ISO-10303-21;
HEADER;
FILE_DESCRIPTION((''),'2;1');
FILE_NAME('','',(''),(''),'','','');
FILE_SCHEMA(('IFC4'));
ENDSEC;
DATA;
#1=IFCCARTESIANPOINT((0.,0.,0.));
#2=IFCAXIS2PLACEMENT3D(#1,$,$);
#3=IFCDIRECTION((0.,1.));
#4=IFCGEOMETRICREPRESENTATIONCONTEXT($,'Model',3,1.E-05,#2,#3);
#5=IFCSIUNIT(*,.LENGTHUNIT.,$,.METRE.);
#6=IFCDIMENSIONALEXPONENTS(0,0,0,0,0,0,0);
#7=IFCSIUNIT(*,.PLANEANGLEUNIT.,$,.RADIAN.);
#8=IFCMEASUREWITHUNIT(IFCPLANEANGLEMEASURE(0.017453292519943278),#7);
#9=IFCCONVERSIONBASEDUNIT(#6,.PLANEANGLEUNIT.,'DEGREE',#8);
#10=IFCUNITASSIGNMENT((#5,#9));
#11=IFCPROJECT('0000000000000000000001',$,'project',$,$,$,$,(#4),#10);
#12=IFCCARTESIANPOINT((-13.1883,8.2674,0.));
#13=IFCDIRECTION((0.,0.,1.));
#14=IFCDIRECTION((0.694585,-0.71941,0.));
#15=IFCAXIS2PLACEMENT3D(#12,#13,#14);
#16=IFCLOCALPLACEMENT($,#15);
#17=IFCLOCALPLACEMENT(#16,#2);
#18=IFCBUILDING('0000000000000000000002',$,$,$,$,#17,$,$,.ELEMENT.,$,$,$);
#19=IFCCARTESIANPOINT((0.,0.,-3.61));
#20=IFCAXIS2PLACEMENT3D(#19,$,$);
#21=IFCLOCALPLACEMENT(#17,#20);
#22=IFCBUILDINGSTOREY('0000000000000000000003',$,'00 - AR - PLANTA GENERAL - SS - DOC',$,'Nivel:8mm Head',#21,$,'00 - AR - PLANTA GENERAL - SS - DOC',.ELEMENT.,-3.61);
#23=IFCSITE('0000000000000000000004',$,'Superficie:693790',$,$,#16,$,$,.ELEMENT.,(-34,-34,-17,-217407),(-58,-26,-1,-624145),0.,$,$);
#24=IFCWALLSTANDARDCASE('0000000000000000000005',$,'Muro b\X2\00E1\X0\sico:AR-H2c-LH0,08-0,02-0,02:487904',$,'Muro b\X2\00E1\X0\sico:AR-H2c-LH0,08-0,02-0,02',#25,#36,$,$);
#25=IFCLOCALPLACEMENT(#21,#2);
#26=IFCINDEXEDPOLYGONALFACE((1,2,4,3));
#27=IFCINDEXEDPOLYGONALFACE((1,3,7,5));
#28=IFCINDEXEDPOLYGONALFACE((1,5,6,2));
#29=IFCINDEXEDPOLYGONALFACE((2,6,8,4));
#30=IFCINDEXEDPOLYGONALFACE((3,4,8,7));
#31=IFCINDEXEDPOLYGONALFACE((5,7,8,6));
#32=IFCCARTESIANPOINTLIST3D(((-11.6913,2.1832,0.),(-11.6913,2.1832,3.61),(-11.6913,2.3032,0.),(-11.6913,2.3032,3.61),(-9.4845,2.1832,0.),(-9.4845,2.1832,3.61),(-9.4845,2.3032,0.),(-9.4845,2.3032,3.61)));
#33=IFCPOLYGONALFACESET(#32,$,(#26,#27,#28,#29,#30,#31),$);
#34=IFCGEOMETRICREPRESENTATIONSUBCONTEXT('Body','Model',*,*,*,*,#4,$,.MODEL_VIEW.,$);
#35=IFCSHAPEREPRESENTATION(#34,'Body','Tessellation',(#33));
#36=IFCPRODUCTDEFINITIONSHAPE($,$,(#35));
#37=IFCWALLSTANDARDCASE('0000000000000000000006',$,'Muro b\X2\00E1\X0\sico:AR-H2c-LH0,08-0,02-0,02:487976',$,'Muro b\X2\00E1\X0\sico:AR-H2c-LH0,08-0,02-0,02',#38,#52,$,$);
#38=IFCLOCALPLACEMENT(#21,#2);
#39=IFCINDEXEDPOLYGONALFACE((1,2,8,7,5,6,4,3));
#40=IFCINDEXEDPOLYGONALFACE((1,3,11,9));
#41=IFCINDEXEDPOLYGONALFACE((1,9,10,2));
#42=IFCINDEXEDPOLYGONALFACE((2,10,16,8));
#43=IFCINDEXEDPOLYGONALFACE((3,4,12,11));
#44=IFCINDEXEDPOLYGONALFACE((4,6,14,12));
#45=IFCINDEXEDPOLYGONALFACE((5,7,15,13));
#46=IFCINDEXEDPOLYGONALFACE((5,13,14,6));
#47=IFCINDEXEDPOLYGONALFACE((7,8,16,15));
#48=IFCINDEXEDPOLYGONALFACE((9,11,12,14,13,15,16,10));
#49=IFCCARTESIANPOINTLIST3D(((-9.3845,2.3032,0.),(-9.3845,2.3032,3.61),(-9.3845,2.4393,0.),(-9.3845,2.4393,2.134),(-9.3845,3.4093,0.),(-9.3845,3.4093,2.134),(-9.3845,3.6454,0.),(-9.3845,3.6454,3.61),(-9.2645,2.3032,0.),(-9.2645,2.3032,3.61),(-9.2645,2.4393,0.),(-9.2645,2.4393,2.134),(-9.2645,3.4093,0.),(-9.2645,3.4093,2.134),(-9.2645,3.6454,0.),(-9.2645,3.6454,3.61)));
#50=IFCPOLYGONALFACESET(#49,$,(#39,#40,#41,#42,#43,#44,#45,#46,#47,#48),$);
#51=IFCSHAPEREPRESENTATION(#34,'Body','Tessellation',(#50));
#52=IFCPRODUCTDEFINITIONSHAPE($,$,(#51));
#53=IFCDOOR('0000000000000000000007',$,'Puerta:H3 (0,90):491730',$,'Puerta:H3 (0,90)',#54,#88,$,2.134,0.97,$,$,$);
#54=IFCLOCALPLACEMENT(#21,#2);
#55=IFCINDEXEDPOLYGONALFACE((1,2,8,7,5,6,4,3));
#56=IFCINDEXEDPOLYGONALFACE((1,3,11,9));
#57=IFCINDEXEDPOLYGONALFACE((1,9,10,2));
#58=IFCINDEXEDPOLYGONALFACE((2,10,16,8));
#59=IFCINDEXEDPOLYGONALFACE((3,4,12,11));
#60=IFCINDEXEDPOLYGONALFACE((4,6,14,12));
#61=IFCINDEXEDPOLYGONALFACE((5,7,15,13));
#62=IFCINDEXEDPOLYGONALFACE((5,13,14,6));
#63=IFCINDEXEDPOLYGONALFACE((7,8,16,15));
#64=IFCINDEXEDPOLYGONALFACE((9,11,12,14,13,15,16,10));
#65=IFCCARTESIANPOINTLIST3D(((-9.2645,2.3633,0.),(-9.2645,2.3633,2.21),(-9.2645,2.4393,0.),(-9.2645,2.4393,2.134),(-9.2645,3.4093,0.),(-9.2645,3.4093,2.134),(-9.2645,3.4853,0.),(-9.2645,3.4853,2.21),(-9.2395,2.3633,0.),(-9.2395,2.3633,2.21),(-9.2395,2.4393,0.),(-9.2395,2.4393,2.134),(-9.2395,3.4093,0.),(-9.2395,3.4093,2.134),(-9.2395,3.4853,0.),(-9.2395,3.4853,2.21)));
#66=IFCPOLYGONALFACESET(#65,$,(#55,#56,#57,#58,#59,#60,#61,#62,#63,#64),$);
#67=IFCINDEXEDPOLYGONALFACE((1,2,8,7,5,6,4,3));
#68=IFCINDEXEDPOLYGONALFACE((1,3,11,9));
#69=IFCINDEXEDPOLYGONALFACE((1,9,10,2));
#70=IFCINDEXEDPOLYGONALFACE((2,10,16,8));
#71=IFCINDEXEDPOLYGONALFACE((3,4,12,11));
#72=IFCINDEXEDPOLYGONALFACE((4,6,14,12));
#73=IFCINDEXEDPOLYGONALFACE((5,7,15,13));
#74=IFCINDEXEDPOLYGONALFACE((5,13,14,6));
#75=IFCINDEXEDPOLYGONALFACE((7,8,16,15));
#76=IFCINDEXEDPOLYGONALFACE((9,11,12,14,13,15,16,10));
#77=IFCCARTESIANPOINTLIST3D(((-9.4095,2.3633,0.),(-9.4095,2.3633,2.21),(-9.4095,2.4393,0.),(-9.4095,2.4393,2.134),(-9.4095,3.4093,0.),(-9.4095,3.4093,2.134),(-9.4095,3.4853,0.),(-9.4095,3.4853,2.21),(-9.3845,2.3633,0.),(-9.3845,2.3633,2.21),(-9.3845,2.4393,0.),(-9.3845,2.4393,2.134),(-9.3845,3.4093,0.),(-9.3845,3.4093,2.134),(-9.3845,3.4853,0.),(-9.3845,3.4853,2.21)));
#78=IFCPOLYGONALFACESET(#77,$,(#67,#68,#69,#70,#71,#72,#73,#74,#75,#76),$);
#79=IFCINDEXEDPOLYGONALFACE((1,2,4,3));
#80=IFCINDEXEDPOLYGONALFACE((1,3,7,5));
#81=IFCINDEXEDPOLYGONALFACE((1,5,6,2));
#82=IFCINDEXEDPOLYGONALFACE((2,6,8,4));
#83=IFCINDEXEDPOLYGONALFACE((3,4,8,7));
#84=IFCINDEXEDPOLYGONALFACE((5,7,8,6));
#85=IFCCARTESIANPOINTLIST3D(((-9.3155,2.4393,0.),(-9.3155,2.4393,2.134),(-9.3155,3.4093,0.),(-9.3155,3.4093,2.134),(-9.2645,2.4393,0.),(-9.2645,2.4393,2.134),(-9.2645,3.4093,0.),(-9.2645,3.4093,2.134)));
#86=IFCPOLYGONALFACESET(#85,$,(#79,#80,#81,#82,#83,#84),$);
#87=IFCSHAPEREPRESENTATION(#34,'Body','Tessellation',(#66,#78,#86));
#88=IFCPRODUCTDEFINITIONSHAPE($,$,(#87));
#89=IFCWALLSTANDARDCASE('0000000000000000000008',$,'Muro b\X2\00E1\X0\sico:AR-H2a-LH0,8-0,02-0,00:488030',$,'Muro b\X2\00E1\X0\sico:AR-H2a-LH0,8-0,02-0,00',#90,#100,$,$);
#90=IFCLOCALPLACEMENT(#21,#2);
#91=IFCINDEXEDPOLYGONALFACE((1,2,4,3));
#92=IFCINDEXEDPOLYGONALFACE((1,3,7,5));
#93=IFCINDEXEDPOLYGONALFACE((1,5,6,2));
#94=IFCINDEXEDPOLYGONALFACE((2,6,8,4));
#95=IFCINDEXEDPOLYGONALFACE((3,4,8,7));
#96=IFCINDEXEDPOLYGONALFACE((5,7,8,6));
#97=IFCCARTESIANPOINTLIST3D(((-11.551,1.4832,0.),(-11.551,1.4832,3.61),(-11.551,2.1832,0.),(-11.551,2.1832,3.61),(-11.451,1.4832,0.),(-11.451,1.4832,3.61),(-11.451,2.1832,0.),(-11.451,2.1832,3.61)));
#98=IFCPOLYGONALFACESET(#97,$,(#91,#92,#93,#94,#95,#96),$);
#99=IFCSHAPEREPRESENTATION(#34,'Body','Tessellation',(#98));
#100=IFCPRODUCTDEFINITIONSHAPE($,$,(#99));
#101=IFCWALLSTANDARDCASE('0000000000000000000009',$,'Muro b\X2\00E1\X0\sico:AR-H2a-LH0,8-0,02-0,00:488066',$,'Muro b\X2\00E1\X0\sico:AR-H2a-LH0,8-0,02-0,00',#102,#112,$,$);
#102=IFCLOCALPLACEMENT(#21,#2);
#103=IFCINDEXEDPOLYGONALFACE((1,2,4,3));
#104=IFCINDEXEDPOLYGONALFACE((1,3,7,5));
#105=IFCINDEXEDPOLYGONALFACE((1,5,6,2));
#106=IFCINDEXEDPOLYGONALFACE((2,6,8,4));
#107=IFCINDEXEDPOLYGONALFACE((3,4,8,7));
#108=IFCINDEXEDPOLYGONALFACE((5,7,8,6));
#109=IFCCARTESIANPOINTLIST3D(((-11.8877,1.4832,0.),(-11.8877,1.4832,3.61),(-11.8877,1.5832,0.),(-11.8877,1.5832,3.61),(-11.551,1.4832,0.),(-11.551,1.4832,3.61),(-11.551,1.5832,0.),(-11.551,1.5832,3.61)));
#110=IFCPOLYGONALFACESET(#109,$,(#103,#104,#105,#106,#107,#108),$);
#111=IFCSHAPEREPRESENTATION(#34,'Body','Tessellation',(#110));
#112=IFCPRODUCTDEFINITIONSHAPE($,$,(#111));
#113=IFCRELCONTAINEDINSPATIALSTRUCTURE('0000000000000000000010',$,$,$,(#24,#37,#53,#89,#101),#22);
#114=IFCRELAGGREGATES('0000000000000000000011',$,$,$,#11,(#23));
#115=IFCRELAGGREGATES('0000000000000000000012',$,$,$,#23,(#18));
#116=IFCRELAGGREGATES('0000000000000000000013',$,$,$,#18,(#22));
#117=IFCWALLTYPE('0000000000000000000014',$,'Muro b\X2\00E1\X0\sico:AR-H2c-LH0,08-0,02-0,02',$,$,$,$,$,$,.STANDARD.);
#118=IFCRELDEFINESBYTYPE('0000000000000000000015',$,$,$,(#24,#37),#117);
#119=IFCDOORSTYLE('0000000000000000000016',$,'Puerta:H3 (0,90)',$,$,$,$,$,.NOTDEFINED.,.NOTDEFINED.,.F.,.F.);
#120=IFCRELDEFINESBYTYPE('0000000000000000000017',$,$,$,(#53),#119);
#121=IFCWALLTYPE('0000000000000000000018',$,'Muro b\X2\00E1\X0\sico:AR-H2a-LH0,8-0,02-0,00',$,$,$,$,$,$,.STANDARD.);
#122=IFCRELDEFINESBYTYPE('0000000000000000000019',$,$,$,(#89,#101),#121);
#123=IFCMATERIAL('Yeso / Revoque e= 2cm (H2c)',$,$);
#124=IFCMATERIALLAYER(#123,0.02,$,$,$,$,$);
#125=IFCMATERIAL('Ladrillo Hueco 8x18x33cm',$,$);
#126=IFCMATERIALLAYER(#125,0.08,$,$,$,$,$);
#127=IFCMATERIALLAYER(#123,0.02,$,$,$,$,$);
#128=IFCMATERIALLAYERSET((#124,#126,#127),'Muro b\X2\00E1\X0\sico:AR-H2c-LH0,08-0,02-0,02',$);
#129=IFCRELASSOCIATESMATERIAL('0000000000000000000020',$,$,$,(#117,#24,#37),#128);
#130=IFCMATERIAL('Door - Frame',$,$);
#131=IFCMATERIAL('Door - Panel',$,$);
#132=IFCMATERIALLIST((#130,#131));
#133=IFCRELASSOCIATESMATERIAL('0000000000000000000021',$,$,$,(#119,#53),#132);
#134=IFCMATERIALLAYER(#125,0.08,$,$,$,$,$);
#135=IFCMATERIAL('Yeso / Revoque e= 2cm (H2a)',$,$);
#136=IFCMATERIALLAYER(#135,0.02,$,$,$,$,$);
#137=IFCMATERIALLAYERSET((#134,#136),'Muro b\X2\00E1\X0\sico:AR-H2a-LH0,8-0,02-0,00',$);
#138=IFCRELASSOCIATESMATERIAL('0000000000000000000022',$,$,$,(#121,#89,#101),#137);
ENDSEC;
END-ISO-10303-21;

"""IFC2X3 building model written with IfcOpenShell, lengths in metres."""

from ifc_helpers import new_model, entity, si_unit, converted_unit, direction, frame, frame_2d, origin, origin_2d_with_axis, place, context, subcontext, project, spatial, polyline, rectangle, outline, extrude, source, transform, mapped, material, material_list, layer, layer_set, layer_usage, type_object, type_shapes, element, fill, save


model = new_model("IFC2X3")

# Units and contexts
model_context = context("Model", 3, precision=1e-05, world=origin(), true_north=direction((0.0, 1.0)))
body_context = subcontext(model_context, "Body", "Model", "MODEL_VIEW")
ifc_project = project(units=[si_unit("LENGTHUNIT", "METRE"), converted_unit("PLANEANGLEUNIT", "DEGREE", entity("IfcPlaneAngleMeasure", 0.017453292519943278), si_unit("PLANEANGLEUNIT", "RADIAN"), dimensions=[0, 0, 0, 0, 0, 0, 0])], contexts=[model_context])

# Site, building, storey
site_placement = place(None, frame((-13.1883, 8.2674, 0.0), z_axis=(0.0, 0.0, 1.0), x_axis=(0.694585, -0.71941, 0.0)))
site = spatial("IfcSite", under=ifc_project, at=site_placement, Name="Superficie:693790", CompositionType="ELEMENT", RefLatitude=(-34, -34, -17, -217407), RefLongitude=(-58, -26, -1, -624145), RefElevation=0.0)
building_placement = place(site_placement, origin())
building = spatial("IfcBuilding", under=site, at=building_placement, CompositionType="ELEMENT")
storey_placement = place(building_placement, frame((0.0, 0.0, -3.61)))
storey = spatial("IfcBuildingStorey", under=building, at=storey_placement, Name="00 - AR - PLANTA GENERAL - SS - DOC", ObjectType="Nivel:8mm Head", LongName="00 - AR - PLANTA GENERAL - SS - DOC", CompositionType="ELEMENT", Elevation=-3.61)

# Wall
ifc_material_1 = material(Name="Yeso / Revoque e= 2cm (H2c)")
ifc_layer_1 = layer(ifc_material_1, 0.02)
ifc_material_2 = material(Name="Ladrillo Hueco 8x18x33cm")
ifc_layer_2 = layer(ifc_material_2, 0.08)
ifc_layer_3 = layer(ifc_material_1, 0.02)
ifc_layer_set_1 = layer_set([ifc_layer_1, ifc_layer_2, ifc_layer_3], Name="Muro básico:AR-H2c-LH0,08-0,02-0,02")
ifc_layer_usage_1 = layer_usage(ifc_layer_set_1, "AXIS2", "NEGATIVE", 0.06)
wall_type_1 = type_object("IfcWallType", Name="Muro básico:AR-H2c-LH0,08-0,02-0,02", PredefinedType="STANDARD", material=ifc_layer_set_1)
wall_1_placement = place(storey_placement, frame((-11.6913, 2.2432, 0.0)))
element("IfcWallStandardCase", 1, at=wall_1_placement, inside=storey, type_object=wall_type_1, material=ifc_layer_usage_1, Name="Muro básico:AR-H2c-LH0,08-0,02-0,02:487904", ObjectType="Muro básico:AR-H2c-LH0,08-0,02-0,02", context=body_context, shape_type="SweptSolid", body=[
    extrude(rectangle(XDim=2.2069, YDim=0.12, at=frame_2d((1.1034, 0.0), x_axis=(-1.0, 0.0))), origin(), (0.0, 0.0, 1.0), 3.61),
])

# Wall, opening, door
ifc_layer_usage_2 = layer_usage(ifc_layer_set_1, "AXIS2", "POSITIVE", -0.06)
wall_2_placement = place(storey_placement, frame((-9.3245, 2.3032, 0.0), z_axis=(0.0, 0.0, 1.0), x_axis=(0.0, 1.0, 0.0)))
wall_2 = element("IfcWallStandardCase", 2, at=wall_2_placement, inside=storey, type_object=wall_type_1, material=ifc_layer_usage_2, Name="Muro básico:AR-H2c-LH0,08-0,02-0,02:487976", ObjectType="Muro básico:AR-H2c-LH0,08-0,02-0,02", context=body_context, shape_type="SweptSolid", body=[
    extrude(rectangle(XDim=1.3422, YDim=0.12, at=frame_2d((0.6711, 0.0), x_axis=(-1.0, 0.0))), origin(), (0.0, 0.0, 1.0), 3.61),
])
opening_1_placement = place(wall_2_placement, frame((1.1061, 0.06, 0.0)))
opening_1 = element("IfcOpeningElement", 3, at=opening_1_placement, cuts=wall_2, ObjectType="Opening", context=body_context, shape_type="SweptSolid", body=[
    extrude(rectangle(XDim=0.97, YDim=2.134, at=frame_2d((1.067, 0.485), x_axis=(0.0, -1.0))), frame((0.0, 0.0, 0.0), z_axis=(0.0, -1.0, 0.0), x_axis=(0.0, 0.0, 1.0)), (0.0, 0.0, 1.0), 0.12),
])
ifc_material_3 = material(Name="Door - Frame")
ifc_material_4 = material(Name="Door - Panel")
ifc_material_list_1 = material_list([ifc_material_3, ifc_material_4])
door_style_1 = type_object("IfcDoorStyle", Name="Puerta:H3 (0,90)", ConstructionType="NOTDEFINED", OperationType="NOTDEFINED", ParameterTakesPrecedence=False, Sizeable=False, material=ifc_material_list_1)
shared_shape_1 = source(origin(), body_context, "Body", "SweptSolid", [
    extrude(outline(polyline([(-0.561, -1.124), (0.561, -1.124), (0.561, 1.086), (0.485, 1.086), (0.485, -1.048), (-0.485, -1.048), (-0.485, 1.086), (-0.561, 1.086), (-0.561, -1.124)])), frame((0.485, 0.145, 1.086), z_axis=(0.0, -1.0, 0.0), x_axis=(-1.0, 0.0, 0.0)), (0.0, 0.0, 1.0), 0.025),
    extrude(outline(polyline([(-1.124, -0.561), (1.086, -0.561), (1.086, -0.485), (-1.048, -0.485), (-1.048, 0.485), (1.086, 0.485), (1.086, 0.561), (-1.124, 0.561), (-1.124, -0.561)])), frame((0.485, 0.0, 1.086), z_axis=(0.0, -1.0, 0.0), x_axis=(0.0, 0.0, -1.0)), (0.0, 0.0, 1.0), 0.025),
    extrude(rectangle(XDim=0.97, YDim=0.051, at=origin_2d_with_axis()), frame((0.485, 0.0945, 0.0)), (0.0, 0.0, 1.0), 2.134),
])
type_shapes(door_style_1, [shared_shape_1])
door_1_placement = place(opening_1_placement, frame((0.0, 0.0, 0.0), z_axis=(0.0, 0.0, 1.0), x_axis=(-1.0, 0.0, 0.0)))
door_1 = element("IfcDoor", 4, at=door_1_placement, inside=storey, type_object=door_style_1, material=ifc_material_list_1, Name="Puerta:H3 (0,90):491730", ObjectType="Puerta:H3 (0,90)", OverallHeight=2.134, OverallWidth=0.97, context=body_context, shape_type="MappedRepresentation", body=[
    mapped(shared_shape_1, transform((0.0, 0.0, 0.0), scale=1.0)),
])
fill(opening_1, door_1)

# Walls
ifc_layer_4 = layer(ifc_material_2, 0.08)
ifc_material_5 = material(Name="Yeso / Revoque e= 2cm (H2a)")
ifc_layer_5 = layer(ifc_material_5, 0.02)
ifc_layer_set_2 = layer_set([ifc_layer_4, ifc_layer_5], Name="Muro básico:AR-H2a-LH0,8-0,02-0,00")
ifc_layer_usage_3 = layer_usage(ifc_layer_set_2, "AXIS2", "NEGATIVE", 0.05)
wall_type_2 = type_object("IfcWallType", Name="Muro básico:AR-H2a-LH0,8-0,02-0,00", PredefinedType="STANDARD", material=ifc_layer_set_2)
wall_3_placement = place(storey_placement, frame((-11.501, 2.1832, 0.0), z_axis=(0.0, 0.0, 1.0), x_axis=(0.0, -1.0, 0.0)))
element("IfcWallStandardCase", 5, at=wall_3_placement, inside=storey, type_object=wall_type_2, material=ifc_layer_usage_3, Name="Muro básico:AR-H2a-LH0,8-0,02-0,00:488030", ObjectType="Muro básico:AR-H2a-LH0,8-0,02-0,00", context=body_context, shape_type="SweptSolid", body=[
    extrude(rectangle(XDim=0.7, YDim=0.1, at=frame_2d((0.35, 0.0), x_axis=(-1.0, 0.0))), origin(), (0.0, 0.0, 1.0), 3.61),
])
ifc_layer_usage_4 = layer_usage(ifc_layer_set_2, "AXIS2", "NEGATIVE", 0.05)
wall_4_placement = place(storey_placement, frame((-11.551, 1.5332, 0.0), z_axis=(0.0, 0.0, 1.0), x_axis=(-1.0, 0.0, 0.0)))
element("IfcWallStandardCase", 6, at=wall_4_placement, inside=storey, type_object=wall_type_2, material=ifc_layer_usage_4, Name="Muro básico:AR-H2a-LH0,8-0,02-0,00:488066", ObjectType="Muro básico:AR-H2a-LH0,8-0,02-0,00", context=body_context, shape_type="SweptSolid", body=[
    extrude(rectangle(XDim=0.3367, YDim=0.1, at=frame_2d((0.1683, 0.0), x_axis=(-1.0, 0.0))), origin(), (0.0, 0.0, 1.0), 3.61),
])

save(model, "model.ifc")
